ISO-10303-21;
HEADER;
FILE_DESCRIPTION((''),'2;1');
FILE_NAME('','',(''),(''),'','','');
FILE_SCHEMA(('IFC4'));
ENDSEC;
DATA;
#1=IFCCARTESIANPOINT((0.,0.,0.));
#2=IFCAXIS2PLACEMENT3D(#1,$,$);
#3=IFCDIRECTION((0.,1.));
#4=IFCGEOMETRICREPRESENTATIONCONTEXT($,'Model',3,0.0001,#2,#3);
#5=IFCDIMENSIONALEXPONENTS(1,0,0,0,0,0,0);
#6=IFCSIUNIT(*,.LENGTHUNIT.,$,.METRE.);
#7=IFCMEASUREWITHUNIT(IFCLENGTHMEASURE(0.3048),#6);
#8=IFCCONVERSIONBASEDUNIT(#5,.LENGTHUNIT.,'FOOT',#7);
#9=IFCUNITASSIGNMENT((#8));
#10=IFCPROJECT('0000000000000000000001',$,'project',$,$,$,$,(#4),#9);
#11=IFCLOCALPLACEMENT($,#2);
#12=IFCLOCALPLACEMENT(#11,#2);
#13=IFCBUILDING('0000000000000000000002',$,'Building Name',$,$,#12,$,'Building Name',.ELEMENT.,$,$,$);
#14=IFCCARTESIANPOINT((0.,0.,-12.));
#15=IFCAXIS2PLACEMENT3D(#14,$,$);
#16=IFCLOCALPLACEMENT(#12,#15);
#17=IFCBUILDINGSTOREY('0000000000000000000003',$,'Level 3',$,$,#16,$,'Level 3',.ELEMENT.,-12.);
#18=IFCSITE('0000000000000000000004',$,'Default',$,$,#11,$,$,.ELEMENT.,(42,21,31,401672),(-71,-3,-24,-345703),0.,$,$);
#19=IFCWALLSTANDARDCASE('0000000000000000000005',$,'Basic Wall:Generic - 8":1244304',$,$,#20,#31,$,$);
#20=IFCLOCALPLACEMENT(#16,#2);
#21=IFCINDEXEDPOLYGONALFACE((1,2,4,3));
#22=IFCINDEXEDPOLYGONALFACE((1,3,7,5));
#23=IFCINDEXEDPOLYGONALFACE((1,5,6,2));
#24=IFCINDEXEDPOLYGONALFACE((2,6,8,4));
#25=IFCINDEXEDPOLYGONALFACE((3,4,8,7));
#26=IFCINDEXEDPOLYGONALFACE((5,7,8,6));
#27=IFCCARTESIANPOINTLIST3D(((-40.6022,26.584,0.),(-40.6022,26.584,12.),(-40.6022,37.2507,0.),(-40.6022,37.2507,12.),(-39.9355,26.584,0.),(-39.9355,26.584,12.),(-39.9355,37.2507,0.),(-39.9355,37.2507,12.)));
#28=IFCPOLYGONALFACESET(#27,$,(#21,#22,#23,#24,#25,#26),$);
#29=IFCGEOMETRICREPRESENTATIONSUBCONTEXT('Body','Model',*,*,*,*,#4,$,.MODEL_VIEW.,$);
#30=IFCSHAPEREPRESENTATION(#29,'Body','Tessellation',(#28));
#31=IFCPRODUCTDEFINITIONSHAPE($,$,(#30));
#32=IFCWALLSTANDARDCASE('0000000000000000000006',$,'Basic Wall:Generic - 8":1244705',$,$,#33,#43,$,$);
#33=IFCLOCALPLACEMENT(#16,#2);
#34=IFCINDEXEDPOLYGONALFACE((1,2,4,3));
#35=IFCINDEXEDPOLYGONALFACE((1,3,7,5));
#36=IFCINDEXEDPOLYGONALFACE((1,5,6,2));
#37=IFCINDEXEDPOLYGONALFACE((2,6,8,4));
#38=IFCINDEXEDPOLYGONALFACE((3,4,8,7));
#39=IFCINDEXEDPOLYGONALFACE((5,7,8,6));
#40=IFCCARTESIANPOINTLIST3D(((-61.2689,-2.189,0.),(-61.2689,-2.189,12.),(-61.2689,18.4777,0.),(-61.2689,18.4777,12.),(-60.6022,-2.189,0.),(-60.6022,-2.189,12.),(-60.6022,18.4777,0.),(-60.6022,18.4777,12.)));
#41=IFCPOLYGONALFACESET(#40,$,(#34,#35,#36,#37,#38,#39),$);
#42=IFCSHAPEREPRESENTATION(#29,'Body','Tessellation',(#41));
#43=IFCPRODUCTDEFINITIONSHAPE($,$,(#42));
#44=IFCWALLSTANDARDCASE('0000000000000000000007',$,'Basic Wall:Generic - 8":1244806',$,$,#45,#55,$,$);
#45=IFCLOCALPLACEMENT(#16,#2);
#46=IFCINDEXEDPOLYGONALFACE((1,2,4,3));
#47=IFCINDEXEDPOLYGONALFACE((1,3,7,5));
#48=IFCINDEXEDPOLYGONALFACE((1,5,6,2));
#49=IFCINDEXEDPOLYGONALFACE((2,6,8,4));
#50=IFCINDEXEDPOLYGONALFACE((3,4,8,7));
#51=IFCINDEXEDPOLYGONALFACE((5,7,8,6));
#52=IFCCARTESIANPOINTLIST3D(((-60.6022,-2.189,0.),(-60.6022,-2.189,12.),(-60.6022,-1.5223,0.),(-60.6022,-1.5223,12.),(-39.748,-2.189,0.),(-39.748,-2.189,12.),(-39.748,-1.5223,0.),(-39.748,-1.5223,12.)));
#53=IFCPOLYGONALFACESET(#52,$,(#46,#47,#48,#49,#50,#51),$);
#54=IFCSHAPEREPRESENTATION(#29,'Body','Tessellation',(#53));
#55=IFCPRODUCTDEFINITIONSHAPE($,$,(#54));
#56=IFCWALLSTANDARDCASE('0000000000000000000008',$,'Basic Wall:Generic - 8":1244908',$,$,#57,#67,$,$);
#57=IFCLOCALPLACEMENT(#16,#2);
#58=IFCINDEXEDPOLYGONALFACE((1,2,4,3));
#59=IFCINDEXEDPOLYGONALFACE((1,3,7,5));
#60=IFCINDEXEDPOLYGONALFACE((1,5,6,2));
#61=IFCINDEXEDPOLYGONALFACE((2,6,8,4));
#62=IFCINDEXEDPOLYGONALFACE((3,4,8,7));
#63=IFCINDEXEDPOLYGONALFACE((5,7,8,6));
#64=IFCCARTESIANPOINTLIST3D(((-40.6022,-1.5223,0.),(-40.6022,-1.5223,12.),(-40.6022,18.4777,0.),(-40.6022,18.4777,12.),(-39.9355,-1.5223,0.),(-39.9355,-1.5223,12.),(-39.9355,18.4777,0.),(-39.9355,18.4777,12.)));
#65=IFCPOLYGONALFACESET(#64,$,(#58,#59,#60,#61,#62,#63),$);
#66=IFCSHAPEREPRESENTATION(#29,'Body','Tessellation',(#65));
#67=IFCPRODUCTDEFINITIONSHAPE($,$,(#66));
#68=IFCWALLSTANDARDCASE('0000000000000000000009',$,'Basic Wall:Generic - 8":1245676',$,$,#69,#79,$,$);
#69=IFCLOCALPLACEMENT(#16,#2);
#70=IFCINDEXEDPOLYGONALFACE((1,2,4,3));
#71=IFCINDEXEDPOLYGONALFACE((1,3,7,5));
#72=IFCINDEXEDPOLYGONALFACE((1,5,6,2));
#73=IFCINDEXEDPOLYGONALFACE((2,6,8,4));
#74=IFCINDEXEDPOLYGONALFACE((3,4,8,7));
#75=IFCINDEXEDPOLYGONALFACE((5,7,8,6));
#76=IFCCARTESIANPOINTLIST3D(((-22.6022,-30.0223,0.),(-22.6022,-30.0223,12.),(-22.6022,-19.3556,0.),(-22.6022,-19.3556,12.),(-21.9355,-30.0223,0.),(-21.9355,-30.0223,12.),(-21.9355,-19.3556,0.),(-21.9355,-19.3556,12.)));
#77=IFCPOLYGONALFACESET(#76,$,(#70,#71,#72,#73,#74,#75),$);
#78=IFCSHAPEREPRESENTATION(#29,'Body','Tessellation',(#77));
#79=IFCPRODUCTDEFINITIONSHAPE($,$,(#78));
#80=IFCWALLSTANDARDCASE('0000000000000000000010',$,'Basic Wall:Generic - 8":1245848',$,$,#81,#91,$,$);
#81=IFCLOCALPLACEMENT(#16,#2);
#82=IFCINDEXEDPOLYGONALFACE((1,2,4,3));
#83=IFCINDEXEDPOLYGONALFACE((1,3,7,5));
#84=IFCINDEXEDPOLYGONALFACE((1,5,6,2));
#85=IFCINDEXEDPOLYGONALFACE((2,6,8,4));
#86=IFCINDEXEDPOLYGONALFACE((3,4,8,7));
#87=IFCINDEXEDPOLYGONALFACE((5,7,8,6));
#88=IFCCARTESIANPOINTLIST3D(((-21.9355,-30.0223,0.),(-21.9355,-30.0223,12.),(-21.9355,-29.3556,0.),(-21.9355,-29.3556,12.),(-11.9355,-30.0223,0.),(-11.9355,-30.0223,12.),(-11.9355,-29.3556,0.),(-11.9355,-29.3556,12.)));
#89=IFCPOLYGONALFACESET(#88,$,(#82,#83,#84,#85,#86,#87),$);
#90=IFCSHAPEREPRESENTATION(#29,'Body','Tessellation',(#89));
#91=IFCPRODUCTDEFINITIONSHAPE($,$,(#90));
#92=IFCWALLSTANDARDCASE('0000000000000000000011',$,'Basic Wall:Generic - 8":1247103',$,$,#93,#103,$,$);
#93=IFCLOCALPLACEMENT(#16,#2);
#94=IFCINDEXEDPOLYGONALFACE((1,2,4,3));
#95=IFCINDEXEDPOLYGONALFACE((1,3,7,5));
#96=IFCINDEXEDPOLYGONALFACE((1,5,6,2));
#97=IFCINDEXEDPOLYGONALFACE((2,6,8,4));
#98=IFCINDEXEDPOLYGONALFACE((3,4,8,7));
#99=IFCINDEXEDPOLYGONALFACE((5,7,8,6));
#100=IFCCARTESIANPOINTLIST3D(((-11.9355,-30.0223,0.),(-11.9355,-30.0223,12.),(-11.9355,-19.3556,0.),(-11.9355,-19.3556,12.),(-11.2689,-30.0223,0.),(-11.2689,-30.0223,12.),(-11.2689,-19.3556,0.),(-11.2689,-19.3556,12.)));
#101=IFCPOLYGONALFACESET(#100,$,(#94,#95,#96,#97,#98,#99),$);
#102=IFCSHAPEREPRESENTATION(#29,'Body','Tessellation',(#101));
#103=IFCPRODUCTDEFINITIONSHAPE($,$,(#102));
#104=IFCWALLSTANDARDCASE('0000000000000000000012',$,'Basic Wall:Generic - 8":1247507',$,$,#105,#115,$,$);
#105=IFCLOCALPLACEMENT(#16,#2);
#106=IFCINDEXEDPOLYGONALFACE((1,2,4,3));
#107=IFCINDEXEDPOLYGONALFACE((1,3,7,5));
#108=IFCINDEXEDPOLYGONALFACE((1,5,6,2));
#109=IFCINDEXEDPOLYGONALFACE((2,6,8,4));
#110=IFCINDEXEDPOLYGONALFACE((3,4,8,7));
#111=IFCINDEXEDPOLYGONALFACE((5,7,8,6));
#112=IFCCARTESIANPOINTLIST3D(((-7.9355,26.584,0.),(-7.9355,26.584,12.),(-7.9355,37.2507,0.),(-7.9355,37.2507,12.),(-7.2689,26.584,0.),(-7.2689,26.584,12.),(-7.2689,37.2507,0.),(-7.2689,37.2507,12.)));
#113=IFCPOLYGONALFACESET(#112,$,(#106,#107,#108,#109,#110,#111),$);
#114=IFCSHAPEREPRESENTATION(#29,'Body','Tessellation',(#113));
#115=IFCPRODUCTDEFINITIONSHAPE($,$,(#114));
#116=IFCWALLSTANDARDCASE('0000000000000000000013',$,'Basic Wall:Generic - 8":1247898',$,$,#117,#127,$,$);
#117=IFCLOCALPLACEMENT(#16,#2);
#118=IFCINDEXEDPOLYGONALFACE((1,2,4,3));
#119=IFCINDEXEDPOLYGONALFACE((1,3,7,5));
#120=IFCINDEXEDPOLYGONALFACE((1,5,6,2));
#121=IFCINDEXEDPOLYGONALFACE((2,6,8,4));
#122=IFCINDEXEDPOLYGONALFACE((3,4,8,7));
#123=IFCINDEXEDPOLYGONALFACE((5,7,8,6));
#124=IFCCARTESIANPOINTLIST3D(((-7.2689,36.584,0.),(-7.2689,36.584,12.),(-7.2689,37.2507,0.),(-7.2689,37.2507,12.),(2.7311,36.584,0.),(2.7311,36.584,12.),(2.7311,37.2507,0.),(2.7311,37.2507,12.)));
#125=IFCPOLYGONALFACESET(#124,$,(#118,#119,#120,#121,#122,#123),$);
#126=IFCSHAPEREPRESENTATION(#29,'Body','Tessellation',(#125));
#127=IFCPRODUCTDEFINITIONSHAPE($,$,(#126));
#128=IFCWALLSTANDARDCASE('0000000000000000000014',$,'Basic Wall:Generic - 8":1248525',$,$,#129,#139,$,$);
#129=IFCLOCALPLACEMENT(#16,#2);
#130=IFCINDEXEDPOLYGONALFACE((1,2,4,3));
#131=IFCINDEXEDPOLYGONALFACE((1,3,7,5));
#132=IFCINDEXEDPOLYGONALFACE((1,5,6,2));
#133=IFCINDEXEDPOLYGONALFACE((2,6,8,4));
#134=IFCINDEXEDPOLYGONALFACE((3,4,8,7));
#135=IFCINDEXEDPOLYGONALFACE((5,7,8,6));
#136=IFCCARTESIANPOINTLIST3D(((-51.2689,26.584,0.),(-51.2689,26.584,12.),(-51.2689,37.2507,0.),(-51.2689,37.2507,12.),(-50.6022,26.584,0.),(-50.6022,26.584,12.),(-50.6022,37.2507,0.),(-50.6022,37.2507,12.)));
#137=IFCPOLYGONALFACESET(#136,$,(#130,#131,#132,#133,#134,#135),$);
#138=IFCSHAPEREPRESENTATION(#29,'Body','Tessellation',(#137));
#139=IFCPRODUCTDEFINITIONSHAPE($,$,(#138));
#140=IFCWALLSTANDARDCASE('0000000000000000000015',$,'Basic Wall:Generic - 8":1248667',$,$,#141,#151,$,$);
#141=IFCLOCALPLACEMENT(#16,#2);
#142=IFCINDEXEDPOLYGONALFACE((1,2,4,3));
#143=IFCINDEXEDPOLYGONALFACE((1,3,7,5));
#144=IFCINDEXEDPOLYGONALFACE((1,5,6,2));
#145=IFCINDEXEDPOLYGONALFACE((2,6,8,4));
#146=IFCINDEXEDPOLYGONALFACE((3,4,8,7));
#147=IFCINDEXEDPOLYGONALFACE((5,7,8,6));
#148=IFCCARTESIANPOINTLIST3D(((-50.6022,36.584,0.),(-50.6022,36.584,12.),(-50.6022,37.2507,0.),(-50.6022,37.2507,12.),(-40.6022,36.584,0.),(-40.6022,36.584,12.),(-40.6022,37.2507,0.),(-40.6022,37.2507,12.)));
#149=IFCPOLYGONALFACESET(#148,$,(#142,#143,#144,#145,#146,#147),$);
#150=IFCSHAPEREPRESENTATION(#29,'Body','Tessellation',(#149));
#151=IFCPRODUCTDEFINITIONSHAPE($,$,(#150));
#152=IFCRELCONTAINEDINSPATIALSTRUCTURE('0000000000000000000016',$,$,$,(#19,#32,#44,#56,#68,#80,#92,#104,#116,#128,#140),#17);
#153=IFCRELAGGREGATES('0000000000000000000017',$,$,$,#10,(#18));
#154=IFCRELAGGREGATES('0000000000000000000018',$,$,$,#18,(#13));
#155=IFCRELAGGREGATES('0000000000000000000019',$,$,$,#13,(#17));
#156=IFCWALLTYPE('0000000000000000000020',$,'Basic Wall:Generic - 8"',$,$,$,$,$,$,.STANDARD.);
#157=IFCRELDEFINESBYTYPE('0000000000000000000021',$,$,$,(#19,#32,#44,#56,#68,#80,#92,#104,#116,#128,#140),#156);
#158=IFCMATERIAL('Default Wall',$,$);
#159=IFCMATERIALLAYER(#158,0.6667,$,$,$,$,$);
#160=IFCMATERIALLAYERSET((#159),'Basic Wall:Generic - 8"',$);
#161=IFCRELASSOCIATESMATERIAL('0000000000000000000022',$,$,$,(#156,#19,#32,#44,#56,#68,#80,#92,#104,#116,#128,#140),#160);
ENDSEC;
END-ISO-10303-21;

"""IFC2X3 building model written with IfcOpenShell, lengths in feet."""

from ifc_helpers import new_model, entity, si_unit, converted_unit, direction, frame, frame_2d, origin, place, context, subcontext, project, spatial, rectangle, extrude, material, layer, layer_set, layer_usage, type_object, element, save


model = new_model("IFC2X3")

# Units and contexts
model_context = context("Model", 3, precision=0.0001, world=origin(), true_north=direction((0.0, 1.0)))
body_context = subcontext(model_context, "Body", "Model", "MODEL_VIEW")
ifc_project = project(units=[converted_unit("LENGTHUNIT", "FOOT", entity("IfcLengthMeasure", 0.3048), si_unit("LENGTHUNIT", "METRE"), dimensions=[1, 0, 0, 0, 0, 0, 0])], contexts=[model_context])

# Site, building, storey
site_placement = place(None, origin())
site = spatial("IfcSite", under=ifc_project, at=site_placement, Name="Default", CompositionType="ELEMENT", RefLatitude=(42, 21, 31, 401672), RefLongitude=(-71, -3, -24, -345703), RefElevation=0.0)
building_placement = place(site_placement, origin())
building = spatial("IfcBuilding", under=site, at=building_placement, Name="Building Name", LongName="Building Name", CompositionType="ELEMENT")
storey_placement = place(building_placement, frame((0.0, 0.0, -12.0)))
storey = spatial("IfcBuildingStorey", under=building, at=storey_placement, Name="Level 3", LongName="Level 3", CompositionType="ELEMENT", Elevation=-12.0)

# Walls
ifc_material_1 = material(Name="Default Wall")
ifc_layer_1 = layer(ifc_material_1, 0.6667)
ifc_layer_set_1 = layer_set([ifc_layer_1], Name="Basic Wall:Generic - 8\"")
wall_type_1 = type_object("IfcWallType", Name="Basic Wall:Generic - 8\"", PredefinedType="STANDARD", material=ifc_layer_set_1)
ifc_layer_usage_1 = layer_usage(ifc_layer_set_1, "AXIS2", "NEGATIVE", 0.3333)
wall_1_placement = place(storey_placement, frame((-40.2689, 26.584, 0.0), z_axis=(0.0, 0.0, 1.0), x_axis=(0.0, 1.0, 0.0)))
element("IfcWallStandardCase", 1, at=wall_1_placement, inside=storey, type_object=wall_type_1, material=ifc_layer_usage_1, Name="Basic Wall:Generic - 8\":1244304", context=body_context, shape_type="SweptSolid", body=[
    extrude(rectangle(XDim=10.6667, YDim=0.6667, at=frame_2d((5.3333, 0.0), x_axis=(-1.0, 0.0))), origin(), (0.0, 0.0, 1.0), 12.0),
])
ifc_layer_usage_2 = layer_usage(ifc_layer_set_1, "AXIS2", "NEGATIVE", 0.3333)
wall_2_placement = place(storey_placement, frame((-60.9355, 18.4777, 0.0), z_axis=(0.0, 0.0, 1.0), x_axis=(0.0, -1.0, 0.0)))
element("IfcWallStandardCase", 2, at=wall_2_placement, inside=storey, type_object=wall_type_1, material=ifc_layer_usage_2, Name="Basic Wall:Generic - 8\":1244705", context=body_context, shape_type="SweptSolid", body=[
    extrude(rectangle(XDim=20.6667, YDim=0.6667, at=frame_2d((10.3333, 0.0), x_axis=(-1.0, 0.0))), origin(), (0.0, 0.0, 1.0), 12.0),
])
ifc_layer_usage_3 = layer_usage(ifc_layer_set_1, "AXIS2", "NEGATIVE", 0.3333)
wall_3_placement = place(storey_placement, frame((-60.6022, -1.8556, 0.0)))
element("IfcWallStandardCase", 3, at=wall_3_placement, inside=storey, type_object=wall_type_1, material=ifc_layer_usage_3, Name="Basic Wall:Generic - 8\":1244806", context=body_context, shape_type="SweptSolid", body=[
    extrude(rectangle(XDim=20.8542, YDim=0.6667, at=frame_2d((10.4271, 0.0), x_axis=(-1.0, 0.0))), origin(), (0.0, 0.0, 1.0), 12.0),
])
ifc_layer_usage_4 = layer_usage(ifc_layer_set_1, "AXIS2", "POSITIVE", -0.3333)
wall_4_placement = place(storey_placement, frame((-40.2689, 18.4777, 0.0), z_axis=(0.0, 0.0, 1.0), x_axis=(0.0, -1.0, 0.0)))
element("IfcWallStandardCase", 4, at=wall_4_placement, inside=storey, type_object=wall_type_1, material=ifc_layer_usage_4, Name="Basic Wall:Generic - 8\":1244908", context=body_context, shape_type="SweptSolid", body=[
    extrude(rectangle(XDim=20.0, YDim=0.6667, at=frame_2d((10.0, 0.0), x_axis=(-1.0, 0.0))), origin(), (0.0, 0.0, 1.0), 12.0),
])
ifc_layer_usage_5 = layer_usage(ifc_layer_set_1, "AXIS2", "POSITIVE", -0.3333)
wall_5_placement = place(storey_placement, frame((-22.2689, -19.3556, 0.0), z_axis=(0.0, 0.0, 1.0), x_axis=(0.0, -1.0, 0.0)))
element("IfcWallStandardCase", 5, at=wall_5_placement, inside=storey, type_object=wall_type_1, material=ifc_layer_usage_5, Name="Basic Wall:Generic - 8\":1245676", context=body_context, shape_type="SweptSolid", body=[
    extrude(rectangle(XDim=10.6667, YDim=0.6667, at=frame_2d((5.3333, 0.0), x_axis=(-1.0, 0.0))), origin(), (0.0, 0.0, 1.0), 12.0),
])
ifc_layer_usage_6 = layer_usage(ifc_layer_set_1, "AXIS2", "POSITIVE", -0.3333)
wall_6_placement = place(storey_placement, frame((-21.9355, -29.689, 0.0)))
element("IfcWallStandardCase", 6, at=wall_6_placement, inside=storey, type_object=wall_type_1, material=ifc_layer_usage_6, Name="Basic Wall:Generic - 8\":1245848", context=body_context, shape_type="SweptSolid", body=[
    extrude(rectangle(XDim=10.0, YDim=0.6667, at=frame_2d((5.0, 0.0), x_axis=(-1.0, 0.0))), origin(), (0.0, 0.0, 1.0), 12.0),
])
ifc_layer_usage_7 = layer_usage(ifc_layer_set_1, "AXIS2", "NEGATIVE", 0.3333)
wall_7_placement = place(storey_placement, frame((-11.6022, -19.3556, 0.0), z_axis=(0.0, 0.0, 1.0), x_axis=(0.0, -1.0, 0.0)))
element("IfcWallStandardCase", 7, at=wall_7_placement, inside=storey, type_object=wall_type_1, material=ifc_layer_usage_7, Name="Basic Wall:Generic - 8\":1247103", context=body_context, shape_type="SweptSolid", body=[
    extrude(rectangle(XDim=10.6667, YDim=0.6667, at=frame_2d((5.3333, 0.0), x_axis=(-1.0, 0.0))), origin(), (0.0, 0.0, 1.0), 12.0),
])
ifc_layer_usage_8 = layer_usage(ifc_layer_set_1, "AXIS2", "POSITIVE", -0.3333)
wall_8_placement = place(storey_placement, frame((-7.6022, 37.2507, 0.0), z_axis=(0.0, 0.0, 1.0), x_axis=(0.0, -1.0, 0.0)))
element("IfcWallStandardCase", 8, at=wall_8_placement, inside=storey, type_object=wall_type_1, material=ifc_layer_usage_8, Name="Basic Wall:Generic - 8\":1247507", context=body_context, shape_type="SweptSolid", body=[
    extrude(rectangle(XDim=10.6667, YDim=0.6667, at=frame_2d((5.3333, 0.0), x_axis=(-1.0, 0.0))), origin(), (0.0, 0.0, 1.0), 12.0),
])
ifc_layer_usage_9 = layer_usage(ifc_layer_set_1, "AXIS2", "NEGATIVE", 0.3333)
wall_9_placement = place(storey_placement, frame((-7.2689, 36.9174, 0.0)))
element("IfcWallStandardCase", 9, at=wall_9_placement, inside=storey, type_object=wall_type_1, material=ifc_layer_usage_9, Name="Basic Wall:Generic - 8\":1247898", context=body_context, shape_type="SweptSolid", body=[
    extrude(rectangle(XDim=10.0, YDim=0.6667, at=frame_2d((5.0, 0.0), x_axis=(-1.0, 0.0))), origin(), (0.0, 0.0, 1.0), 12.0),
])
ifc_layer_usage_10 = layer_usage(ifc_layer_set_1, "AXIS2", "NEGATIVE", 0.3333)
wall_10_placement = place(storey_placement, frame((-50.9355, 26.584, 0.0), z_axis=(0.0, 0.0, 1.0), x_axis=(0.0, 1.0, 0.0)))
element("IfcWallStandardCase", 10, at=wall_10_placement, inside=storey, type_object=wall_type_1, material=ifc_layer_usage_10, Name="Basic Wall:Generic - 8\":1248525", context=body_context, shape_type="SweptSolid", body=[
    extrude(rectangle(XDim=10.6667, YDim=0.6667, at=frame_2d((5.3333, 0.0), x_axis=(-1.0, 0.0))), origin(), (0.0, 0.0, 1.0), 12.0),
])
ifc_layer_usage_11 = layer_usage(ifc_layer_set_1, "AXIS2", "POSITIVE", -0.3333)
wall_11_placement = place(storey_placement, frame((-50.6022, 36.9174, 0.0)))
element("IfcWallStandardCase", 11, at=wall_11_placement, inside=storey, type_object=wall_type_1, material=ifc_layer_usage_11, Name="Basic Wall:Generic - 8\":1248667", context=body_context, shape_type="SweptSolid", body=[
    extrude(rectangle(XDim=10.0, YDim=0.6667, at=frame_2d((5.0, 0.0), x_axis=(-1.0, 0.0))), origin(), (0.0, 0.0, 1.0), 12.0),
])

save(model, "model.ifc")
